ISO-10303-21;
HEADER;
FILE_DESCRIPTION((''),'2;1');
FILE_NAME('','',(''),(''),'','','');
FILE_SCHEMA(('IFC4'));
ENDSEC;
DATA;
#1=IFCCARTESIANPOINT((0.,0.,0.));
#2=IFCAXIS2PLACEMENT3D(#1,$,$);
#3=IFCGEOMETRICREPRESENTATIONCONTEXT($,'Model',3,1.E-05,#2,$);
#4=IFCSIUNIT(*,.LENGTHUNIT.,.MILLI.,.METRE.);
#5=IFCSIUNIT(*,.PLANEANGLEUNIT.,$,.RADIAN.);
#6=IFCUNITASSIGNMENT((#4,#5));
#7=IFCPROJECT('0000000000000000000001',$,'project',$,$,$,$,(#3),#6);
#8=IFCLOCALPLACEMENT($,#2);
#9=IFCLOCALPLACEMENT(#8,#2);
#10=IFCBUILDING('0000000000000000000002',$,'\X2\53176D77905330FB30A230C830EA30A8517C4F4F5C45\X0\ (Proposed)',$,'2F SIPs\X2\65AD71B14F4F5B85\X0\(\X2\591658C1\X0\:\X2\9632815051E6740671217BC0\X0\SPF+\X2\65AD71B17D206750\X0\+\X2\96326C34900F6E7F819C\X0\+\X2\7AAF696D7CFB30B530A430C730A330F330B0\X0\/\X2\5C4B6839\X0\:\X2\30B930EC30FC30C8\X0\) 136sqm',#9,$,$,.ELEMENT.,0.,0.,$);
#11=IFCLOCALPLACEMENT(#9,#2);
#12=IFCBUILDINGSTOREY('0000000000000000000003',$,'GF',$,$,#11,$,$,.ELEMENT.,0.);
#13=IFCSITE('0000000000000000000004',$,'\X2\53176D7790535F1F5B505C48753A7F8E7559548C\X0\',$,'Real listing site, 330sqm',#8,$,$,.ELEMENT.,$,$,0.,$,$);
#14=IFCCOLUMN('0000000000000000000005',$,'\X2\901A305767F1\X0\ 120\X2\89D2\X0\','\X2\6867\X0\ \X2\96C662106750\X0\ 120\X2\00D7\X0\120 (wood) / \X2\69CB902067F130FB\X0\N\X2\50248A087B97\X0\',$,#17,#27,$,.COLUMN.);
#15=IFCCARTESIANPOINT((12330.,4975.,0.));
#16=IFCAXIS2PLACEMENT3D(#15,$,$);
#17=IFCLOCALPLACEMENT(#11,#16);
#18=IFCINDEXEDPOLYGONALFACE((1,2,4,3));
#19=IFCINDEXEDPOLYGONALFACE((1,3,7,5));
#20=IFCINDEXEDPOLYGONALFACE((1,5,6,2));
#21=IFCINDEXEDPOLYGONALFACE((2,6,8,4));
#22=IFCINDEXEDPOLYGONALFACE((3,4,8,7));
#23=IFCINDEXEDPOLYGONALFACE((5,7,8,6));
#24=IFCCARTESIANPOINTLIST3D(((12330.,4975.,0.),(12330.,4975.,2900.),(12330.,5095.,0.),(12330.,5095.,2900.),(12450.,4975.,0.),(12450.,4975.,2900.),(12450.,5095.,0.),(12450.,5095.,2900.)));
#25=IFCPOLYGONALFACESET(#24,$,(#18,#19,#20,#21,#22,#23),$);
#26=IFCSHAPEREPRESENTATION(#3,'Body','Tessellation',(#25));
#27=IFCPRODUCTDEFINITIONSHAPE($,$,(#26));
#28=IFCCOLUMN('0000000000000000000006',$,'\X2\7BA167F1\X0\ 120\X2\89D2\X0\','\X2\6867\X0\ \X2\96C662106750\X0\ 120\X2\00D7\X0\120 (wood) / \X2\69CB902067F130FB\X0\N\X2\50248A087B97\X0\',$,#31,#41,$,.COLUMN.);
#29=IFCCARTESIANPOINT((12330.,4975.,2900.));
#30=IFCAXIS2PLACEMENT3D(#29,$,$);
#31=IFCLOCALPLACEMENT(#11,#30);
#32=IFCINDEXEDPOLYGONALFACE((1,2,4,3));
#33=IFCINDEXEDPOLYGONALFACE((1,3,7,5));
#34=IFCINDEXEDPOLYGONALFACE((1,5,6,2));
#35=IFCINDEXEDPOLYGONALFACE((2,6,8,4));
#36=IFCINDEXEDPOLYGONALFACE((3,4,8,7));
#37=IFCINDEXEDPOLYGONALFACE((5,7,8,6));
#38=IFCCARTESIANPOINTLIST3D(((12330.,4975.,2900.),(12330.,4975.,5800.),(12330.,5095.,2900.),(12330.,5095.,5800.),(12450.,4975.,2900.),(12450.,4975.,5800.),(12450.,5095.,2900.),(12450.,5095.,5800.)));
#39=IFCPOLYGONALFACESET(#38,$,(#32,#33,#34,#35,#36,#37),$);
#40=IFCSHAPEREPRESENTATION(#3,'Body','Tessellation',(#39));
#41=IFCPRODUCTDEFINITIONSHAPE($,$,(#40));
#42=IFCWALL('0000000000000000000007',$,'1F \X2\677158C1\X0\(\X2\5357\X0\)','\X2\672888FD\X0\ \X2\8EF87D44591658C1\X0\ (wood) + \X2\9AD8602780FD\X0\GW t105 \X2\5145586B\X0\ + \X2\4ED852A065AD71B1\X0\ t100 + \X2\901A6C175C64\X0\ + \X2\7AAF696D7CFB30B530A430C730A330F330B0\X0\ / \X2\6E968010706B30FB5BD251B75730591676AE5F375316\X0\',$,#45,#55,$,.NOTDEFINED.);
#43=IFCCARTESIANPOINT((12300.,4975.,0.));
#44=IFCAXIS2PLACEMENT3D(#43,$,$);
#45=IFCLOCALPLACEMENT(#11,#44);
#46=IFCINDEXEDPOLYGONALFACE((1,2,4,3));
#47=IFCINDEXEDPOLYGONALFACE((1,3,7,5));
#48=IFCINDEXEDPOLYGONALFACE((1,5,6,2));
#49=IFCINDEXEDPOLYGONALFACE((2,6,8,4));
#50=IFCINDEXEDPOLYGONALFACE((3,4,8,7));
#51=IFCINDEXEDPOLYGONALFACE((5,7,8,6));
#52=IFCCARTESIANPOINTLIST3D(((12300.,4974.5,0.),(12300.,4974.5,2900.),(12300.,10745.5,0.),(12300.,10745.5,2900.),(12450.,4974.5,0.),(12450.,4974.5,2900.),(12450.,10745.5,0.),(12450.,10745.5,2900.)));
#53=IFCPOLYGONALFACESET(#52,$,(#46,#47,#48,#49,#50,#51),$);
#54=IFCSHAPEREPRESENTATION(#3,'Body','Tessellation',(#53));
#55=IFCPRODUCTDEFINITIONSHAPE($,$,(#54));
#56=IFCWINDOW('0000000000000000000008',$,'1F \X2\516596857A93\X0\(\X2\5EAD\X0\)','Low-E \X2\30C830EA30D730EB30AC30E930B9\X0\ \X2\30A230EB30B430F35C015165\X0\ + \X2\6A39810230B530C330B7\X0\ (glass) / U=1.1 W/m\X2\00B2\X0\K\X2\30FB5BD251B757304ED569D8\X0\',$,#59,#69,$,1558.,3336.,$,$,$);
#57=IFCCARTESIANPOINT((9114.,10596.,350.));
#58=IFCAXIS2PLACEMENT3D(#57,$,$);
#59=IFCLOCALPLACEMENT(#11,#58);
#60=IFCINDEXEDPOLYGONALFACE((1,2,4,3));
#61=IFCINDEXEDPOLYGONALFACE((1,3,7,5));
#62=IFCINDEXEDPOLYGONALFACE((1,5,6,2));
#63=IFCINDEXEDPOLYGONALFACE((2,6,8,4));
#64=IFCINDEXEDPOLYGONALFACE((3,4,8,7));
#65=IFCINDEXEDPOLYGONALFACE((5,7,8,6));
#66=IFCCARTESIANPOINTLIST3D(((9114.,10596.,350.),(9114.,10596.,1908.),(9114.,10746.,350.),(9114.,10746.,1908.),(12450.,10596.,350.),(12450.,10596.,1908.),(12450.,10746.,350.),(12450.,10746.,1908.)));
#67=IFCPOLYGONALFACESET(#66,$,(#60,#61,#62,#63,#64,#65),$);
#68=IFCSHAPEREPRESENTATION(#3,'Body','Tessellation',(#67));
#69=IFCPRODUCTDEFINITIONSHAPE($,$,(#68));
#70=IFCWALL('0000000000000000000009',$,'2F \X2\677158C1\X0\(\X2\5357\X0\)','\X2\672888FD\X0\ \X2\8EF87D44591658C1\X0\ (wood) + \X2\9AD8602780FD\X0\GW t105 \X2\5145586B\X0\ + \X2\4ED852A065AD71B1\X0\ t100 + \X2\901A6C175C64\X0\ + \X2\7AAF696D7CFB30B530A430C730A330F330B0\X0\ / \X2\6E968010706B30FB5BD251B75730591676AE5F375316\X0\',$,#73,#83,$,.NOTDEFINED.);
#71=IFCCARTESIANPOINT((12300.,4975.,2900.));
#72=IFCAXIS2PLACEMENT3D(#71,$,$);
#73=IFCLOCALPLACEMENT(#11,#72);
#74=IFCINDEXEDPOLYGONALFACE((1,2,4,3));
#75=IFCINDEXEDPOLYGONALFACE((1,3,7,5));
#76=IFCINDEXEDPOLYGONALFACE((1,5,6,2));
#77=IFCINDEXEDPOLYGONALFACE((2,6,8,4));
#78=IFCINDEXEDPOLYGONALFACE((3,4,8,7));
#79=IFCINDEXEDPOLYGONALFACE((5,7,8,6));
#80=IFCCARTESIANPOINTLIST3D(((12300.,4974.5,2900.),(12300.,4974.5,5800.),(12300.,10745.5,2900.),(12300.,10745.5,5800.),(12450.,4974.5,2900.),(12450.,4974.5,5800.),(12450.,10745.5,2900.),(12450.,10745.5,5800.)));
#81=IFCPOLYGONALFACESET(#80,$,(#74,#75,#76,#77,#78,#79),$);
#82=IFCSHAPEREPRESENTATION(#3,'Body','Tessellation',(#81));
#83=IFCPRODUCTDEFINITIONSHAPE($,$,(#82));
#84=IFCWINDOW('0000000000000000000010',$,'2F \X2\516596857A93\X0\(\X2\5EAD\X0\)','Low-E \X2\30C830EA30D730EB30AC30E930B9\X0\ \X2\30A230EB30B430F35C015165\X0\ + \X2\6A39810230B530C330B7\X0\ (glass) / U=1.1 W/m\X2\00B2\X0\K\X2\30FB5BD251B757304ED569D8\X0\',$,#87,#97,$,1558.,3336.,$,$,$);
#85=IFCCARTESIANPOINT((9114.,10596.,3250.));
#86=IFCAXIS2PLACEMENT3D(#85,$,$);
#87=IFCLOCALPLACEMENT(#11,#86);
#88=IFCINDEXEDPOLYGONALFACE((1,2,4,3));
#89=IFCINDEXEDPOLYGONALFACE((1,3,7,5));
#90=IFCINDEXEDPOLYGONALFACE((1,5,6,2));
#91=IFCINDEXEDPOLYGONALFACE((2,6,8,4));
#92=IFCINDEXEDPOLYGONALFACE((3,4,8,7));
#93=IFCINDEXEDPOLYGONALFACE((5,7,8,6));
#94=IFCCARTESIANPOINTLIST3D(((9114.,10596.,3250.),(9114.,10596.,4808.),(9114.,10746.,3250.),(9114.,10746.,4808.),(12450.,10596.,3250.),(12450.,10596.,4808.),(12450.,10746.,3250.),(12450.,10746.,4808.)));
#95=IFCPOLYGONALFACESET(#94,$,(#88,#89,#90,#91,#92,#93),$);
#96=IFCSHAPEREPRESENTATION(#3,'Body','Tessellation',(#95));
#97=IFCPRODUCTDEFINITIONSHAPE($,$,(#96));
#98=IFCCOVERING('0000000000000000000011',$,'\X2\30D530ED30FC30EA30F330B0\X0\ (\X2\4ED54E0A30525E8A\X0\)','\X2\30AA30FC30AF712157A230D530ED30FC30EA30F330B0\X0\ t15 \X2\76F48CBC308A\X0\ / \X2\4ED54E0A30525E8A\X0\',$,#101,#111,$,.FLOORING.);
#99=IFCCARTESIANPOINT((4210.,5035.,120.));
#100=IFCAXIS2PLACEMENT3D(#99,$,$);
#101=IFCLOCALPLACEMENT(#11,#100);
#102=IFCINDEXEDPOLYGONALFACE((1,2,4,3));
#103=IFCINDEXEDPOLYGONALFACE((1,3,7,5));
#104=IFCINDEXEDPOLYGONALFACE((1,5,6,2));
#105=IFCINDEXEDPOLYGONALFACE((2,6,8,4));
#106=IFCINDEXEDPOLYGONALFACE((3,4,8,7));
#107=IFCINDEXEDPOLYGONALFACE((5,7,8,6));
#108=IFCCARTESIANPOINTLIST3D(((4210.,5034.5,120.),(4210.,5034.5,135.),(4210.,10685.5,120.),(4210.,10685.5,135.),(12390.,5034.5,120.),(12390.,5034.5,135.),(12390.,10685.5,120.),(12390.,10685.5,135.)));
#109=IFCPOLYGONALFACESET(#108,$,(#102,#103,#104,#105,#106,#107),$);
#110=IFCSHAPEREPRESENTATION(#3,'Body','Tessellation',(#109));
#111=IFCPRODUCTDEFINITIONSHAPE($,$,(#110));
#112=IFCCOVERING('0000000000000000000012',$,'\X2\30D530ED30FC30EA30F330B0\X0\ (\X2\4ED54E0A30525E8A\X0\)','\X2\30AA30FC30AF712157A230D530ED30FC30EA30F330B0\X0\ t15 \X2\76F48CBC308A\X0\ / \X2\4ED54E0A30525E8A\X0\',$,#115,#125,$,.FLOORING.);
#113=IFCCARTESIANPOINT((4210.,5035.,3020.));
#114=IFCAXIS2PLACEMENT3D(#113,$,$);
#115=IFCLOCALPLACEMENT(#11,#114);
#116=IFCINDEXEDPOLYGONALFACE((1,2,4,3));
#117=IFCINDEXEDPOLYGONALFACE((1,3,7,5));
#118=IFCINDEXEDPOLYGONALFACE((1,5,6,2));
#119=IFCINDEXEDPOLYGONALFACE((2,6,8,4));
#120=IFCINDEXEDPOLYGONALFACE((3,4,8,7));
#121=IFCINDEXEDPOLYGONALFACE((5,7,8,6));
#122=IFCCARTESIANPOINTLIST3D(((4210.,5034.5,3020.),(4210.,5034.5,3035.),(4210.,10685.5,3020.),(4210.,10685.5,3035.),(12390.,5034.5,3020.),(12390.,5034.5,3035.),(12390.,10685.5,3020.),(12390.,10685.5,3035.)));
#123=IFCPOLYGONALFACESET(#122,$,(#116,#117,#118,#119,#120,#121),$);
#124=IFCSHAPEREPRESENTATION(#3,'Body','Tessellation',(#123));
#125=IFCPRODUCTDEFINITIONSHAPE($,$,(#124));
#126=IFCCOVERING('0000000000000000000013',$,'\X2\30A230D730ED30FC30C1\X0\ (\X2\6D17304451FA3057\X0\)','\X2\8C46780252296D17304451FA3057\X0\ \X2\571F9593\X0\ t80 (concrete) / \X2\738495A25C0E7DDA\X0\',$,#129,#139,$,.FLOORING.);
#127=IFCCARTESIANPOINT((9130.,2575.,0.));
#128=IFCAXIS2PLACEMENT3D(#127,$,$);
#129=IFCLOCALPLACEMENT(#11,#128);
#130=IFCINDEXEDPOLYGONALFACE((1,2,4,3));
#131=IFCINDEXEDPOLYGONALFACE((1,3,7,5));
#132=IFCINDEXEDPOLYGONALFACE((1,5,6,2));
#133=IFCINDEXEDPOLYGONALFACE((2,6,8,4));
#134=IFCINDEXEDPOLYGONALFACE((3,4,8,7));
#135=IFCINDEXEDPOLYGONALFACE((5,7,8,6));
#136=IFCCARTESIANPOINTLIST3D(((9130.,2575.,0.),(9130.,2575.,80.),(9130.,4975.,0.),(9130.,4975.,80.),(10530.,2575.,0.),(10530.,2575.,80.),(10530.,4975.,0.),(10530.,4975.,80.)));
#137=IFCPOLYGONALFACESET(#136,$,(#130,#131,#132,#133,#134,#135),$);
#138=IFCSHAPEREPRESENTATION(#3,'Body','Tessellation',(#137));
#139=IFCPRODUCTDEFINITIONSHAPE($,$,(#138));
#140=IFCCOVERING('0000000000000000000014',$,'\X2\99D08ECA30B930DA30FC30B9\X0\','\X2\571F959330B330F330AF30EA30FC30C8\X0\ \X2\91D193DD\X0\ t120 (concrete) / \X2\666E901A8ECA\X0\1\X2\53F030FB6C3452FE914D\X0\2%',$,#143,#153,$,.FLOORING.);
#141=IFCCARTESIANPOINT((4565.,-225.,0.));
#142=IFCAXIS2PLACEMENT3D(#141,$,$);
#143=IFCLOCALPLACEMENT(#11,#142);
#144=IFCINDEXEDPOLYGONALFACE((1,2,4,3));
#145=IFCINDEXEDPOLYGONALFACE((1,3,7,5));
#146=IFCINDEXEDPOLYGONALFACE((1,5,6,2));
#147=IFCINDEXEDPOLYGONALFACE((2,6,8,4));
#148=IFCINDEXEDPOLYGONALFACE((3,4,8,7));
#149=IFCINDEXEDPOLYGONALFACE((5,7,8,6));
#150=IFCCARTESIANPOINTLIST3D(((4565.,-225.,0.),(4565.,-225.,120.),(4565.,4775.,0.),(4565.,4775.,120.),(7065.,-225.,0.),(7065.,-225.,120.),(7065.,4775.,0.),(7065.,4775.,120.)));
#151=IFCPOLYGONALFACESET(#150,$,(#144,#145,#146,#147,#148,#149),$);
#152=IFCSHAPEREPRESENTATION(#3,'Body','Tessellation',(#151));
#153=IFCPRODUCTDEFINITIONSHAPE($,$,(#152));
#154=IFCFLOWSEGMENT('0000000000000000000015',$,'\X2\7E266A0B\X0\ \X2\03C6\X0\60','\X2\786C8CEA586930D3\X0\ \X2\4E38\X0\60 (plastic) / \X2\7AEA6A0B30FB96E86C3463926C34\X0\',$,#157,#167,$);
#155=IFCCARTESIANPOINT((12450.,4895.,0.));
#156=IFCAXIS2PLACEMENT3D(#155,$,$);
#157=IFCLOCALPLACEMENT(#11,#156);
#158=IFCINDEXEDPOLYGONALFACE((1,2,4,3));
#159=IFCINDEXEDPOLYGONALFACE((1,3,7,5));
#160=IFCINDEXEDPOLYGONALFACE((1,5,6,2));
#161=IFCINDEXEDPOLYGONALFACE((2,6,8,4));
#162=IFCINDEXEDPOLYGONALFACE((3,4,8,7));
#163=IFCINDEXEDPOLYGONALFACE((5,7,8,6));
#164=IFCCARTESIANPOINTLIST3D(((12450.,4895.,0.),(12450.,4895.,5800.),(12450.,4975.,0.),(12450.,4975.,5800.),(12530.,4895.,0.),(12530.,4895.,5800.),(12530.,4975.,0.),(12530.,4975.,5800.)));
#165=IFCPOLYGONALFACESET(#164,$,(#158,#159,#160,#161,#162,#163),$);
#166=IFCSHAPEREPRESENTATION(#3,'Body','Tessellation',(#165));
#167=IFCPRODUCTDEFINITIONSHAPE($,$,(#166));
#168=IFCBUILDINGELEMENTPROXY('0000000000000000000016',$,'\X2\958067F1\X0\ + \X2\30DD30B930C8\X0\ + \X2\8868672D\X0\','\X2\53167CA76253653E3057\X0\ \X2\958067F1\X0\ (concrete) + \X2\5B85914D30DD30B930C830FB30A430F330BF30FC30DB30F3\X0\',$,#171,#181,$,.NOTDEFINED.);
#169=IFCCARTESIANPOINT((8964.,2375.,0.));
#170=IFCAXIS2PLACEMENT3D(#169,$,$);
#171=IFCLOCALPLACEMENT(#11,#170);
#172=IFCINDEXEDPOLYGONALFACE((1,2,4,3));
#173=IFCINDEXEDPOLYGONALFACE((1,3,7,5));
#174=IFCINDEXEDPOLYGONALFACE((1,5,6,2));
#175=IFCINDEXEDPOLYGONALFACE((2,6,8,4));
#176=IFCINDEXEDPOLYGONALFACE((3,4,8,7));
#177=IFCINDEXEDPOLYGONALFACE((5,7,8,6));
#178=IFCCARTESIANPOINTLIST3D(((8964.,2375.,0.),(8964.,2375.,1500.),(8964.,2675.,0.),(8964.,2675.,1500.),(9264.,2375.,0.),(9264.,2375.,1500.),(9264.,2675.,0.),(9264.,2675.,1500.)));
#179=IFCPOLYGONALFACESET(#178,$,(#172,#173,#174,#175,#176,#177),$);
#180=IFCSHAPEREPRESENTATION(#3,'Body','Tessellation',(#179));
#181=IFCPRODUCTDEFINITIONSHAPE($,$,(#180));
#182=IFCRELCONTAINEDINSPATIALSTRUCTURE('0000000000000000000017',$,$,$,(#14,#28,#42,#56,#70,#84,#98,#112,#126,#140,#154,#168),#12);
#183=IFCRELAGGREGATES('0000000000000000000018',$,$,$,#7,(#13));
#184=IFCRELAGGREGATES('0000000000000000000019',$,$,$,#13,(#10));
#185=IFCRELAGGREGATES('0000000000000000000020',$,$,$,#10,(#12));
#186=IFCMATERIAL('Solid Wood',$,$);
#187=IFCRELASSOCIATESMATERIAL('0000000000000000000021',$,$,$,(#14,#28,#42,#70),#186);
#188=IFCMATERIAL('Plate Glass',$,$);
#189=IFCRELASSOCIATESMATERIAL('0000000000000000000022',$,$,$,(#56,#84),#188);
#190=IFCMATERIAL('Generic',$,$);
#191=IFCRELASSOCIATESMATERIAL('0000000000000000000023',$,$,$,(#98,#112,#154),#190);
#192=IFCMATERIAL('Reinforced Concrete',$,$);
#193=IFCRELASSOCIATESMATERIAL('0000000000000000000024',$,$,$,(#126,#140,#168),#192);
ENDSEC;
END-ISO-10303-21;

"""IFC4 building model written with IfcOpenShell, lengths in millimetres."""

from ifc_helpers import new_model, si_unit, frame, frame_2d, origin, place, context, project, spatial, rectangle, extrude, material, element, fill, save


model = new_model("IFC4")

# Units and contexts
model_context = context("Model", 3, precision=1e-05, world=origin())
ifc_project = project(units=[si_unit("LENGTHUNIT", "METRE", prefix="MILLI"), si_unit("PLANEANGLEUNIT", "RADIAN")], contexts=[model_context])

# Site, building, storey
site_placement = place(None, origin())
site = spatial("IfcSite", under=ifc_project, at=site_placement, Name="北海道弟子屈町美留和", ObjectType="Real listing site, 330sqm", CompositionType="ELEMENT", RefElevation=0.0)
building_placement = place(site_placement, origin())
building = spatial("IfcBuilding", under=site, at=building_placement, Name="北海道・アトリエ兼住居 (Proposed)", ObjectType="2F SIPs断熱住宅(外壁:防腐処理無節SPF+断熱素材+防水透湿膜+窯業系サイディング/屋根:スレート) 136sqm", CompositionType="ELEMENT", ElevationOfRefHeight=0.0, ElevationOfTerrain=0.0)
storey_placement = place(building_placement, origin())
storey = spatial("IfcBuildingStorey", under=building, at=storey_placement, Name="GF", CompositionType="ELEMENT", Elevation=0.0)

# Columns
ifc_material_1 = material(Name="Solid Wood")
column_1_placement = place(storey_placement, frame((12330.0, 4975.0, 0.0)))
element("IfcColumn", 1, at=column_1_placement, inside=storey, material=ifc_material_1, Name="通し柱 120角", Description="桧 集成材 120×120 (wood) / 構造柱・N値計算", PredefinedType="COLUMN", context=model_context, shape_type="SweptSolid", body=[
    extrude(rectangle(XDim=120.0, YDim=120.0, at=frame_2d((60.0, 60.0))), frame((12330.0, 4975.0, 0.0)), (0.0, 0.0, 1.0), 2900.0),
])
column_2_placement = place(storey_placement, frame((12330.0, 4975.0, 2900.0)))
element("IfcColumn", 2, at=column_2_placement, inside=storey, material=ifc_material_1, Name="管柱 120角", Description="桧 集成材 120×120 (wood) / 構造柱・N値計算", PredefinedType="COLUMN", context=model_context, shape_type="SweptSolid", body=[
    extrude(rectangle(XDim=120.0, YDim=120.0, at=frame_2d((60.0, 60.0))), frame((12330.0, 4975.0, 2900.0)), (0.0, 0.0, 1.0), 2900.0),
])

# Wall, opening, window
wall_1_placement = place(storey_placement, frame((12300.0, 4975.0, 0.0)))
wall_1 = element("IfcWall", 3, at=wall_1_placement, inside=storey, material=ifc_material_1, Name="1F 東壁(南)", Description="木製 軸組外壁 (wood) + 高性能GW t105 充填 + 付加断熱 t100 + 通気層 + 窯業系サイディング / 準耐火・寒冷地外皮強化", PredefinedType="NOTDEFINED", context=model_context, shape_type="SweptSolid", body=[
    extrude(rectangle(XDim=150.0, YDim=5771.0, at=frame_2d((75.0, 2885.0))), frame((12300.0, 4975.0, 0.0)), (0.0, 0.0, 1.0), 2900.0),
])
opening_1_placement = place(storey_placement, frame((9114.0, 10596.0, 350.0)))
opening_1 = element("IfcOpeningElement", 4, at=opening_1_placement, cuts=wall_1, PredefinedType="NOTDEFINED", context=model_context, shape_type="SweptSolid", body=[
    extrude(rectangle(XDim=3336.0, YDim=150.0, at=frame_2d((1668.0, 75.0))), frame((9114.0, 10596.0, 350.0)), (0.0, 0.0, 1.0), 1558.0),
])
ifc_material_2 = material(Name="Plate Glass")
window_1_placement = place(storey_placement, frame((9114.0, 10596.0, 350.0)))
window_1 = element("IfcWindow", 5, at=window_1_placement, inside=storey, material=ifc_material_2, Name="1F 入隅窓(庭)", Description="Low-E トリプルガラス アルゴン封入 + 樹脂サッシ (glass) / U=1.1 W/m²K・寒冷地仕様", OverallHeight=1558.0, OverallWidth=3336.0, context=model_context, shape_type="SweptSolid", body=[
    extrude(rectangle(XDim=3336.0, YDim=150.0, at=frame_2d((1668.0, 75.0))), frame((9114.0, 10596.0, 350.0)), (0.0, 0.0, 1.0), 1558.0),
])
fill(opening_1, window_1)

# Wall, opening, window
wall_2_placement = place(storey_placement, frame((12300.0, 4975.0, 2900.0)))
wall_2 = element("IfcWall", 6, at=wall_2_placement, inside=storey, material=ifc_material_1, Name="2F 東壁(南)", Description="木製 軸組外壁 (wood) + 高性能GW t105 充填 + 付加断熱 t100 + 通気層 + 窯業系サイディング / 準耐火・寒冷地外皮強化", PredefinedType="NOTDEFINED", context=model_context, shape_type="SweptSolid", body=[
    extrude(rectangle(XDim=150.0, YDim=5771.0, at=frame_2d((75.0, 2885.0))), frame((12300.0, 4975.0, 2900.0)), (0.0, 0.0, 1.0), 2900.0),
])
opening_2_placement = place(storey_placement, frame((9114.0, 10596.0, 3250.0)))
opening_2 = element("IfcOpeningElement", 7, at=opening_2_placement, cuts=wall_2, PredefinedType="NOTDEFINED", context=model_context, shape_type="SweptSolid", body=[
    extrude(rectangle(XDim=3336.0, YDim=150.0, at=frame_2d((1668.0, 75.0))), frame((9114.0, 10596.0, 3250.0)), (0.0, 0.0, 1.0), 1558.0),
])
window_2_placement = place(storey_placement, frame((9114.0, 10596.0, 3250.0)))
window_2 = element("IfcWindow", 8, at=window_2_placement, inside=storey, material=ifc_material_2, Name="2F 入隅窓(庭)", Description="Low-E トリプルガラス アルゴン封入 + 樹脂サッシ (glass) / U=1.1 W/m²K・寒冷地仕様", OverallHeight=1558.0, OverallWidth=3336.0, context=model_context, shape_type="SweptSolid", body=[
    extrude(rectangle(XDim=3336.0, YDim=150.0, at=frame_2d((1668.0, 75.0))), frame((9114.0, 10596.0, 3250.0)), (0.0, 0.0, 1.0), 1558.0),
])
fill(opening_2, window_2)

# Coverings
ifc_material_3 = material(Name="Generic")
covering_1_placement = place(storey_placement, frame((4210.0, 5035.0, 120.0)))
element("IfcCovering", 9, at=covering_1_placement, inside=storey, material=ifc_material_3, Name="フローリング (仕上げ床)", Description="オーク無垢フローリング t15 直貼り / 仕上げ床", PredefinedType="FLOORING", context=model_context, shape_type="SweptSolid", body=[
    extrude(rectangle(XDim=8180.0, YDim=5651.0, at=frame_2d((4090.0, 2825.0))), frame((4210.0, 5035.0, 120.0)), (0.0, 0.0, 1.0), 15.0),
])
covering_2_placement = place(storey_placement, frame((4210.0, 5035.0, 3020.0)))
element("IfcCovering", 10, at=covering_2_placement, inside=storey, material=ifc_material_3, Name="フローリング (仕上げ床)", Description="オーク無垢フローリング t15 直貼り / 仕上げ床", PredefinedType="FLOORING", context=model_context, shape_type="SweptSolid", body=[
    extrude(rectangle(XDim=8180.0, YDim=5651.0, at=frame_2d((4090.0, 2825.0))), frame((4210.0, 5035.0, 3020.0)), (0.0, 0.0, 1.0), 15.0),
])
ifc_material_4 = material(Name="Reinforced Concrete")
covering_3_placement = place(storey_placement, frame((9130.0, 2575.0, 0.0)))
element("IfcCovering", 11, at=covering_3_placement, inside=storey, material=ifc_material_4, Name="アプローチ (洗い出し)", Description="豆砂利洗い出し 土間 t80 (concrete) / 玄関導線", PredefinedType="FLOORING", context=model_context, shape_type="SweptSolid", body=[
    extrude(rectangle(XDim=1400.0, YDim=2400.0, at=frame_2d((700.0, 1200.0))), frame((9130.0, 2575.0, 0.0)), (0.0, 0.0, 1.0), 80.0),
])
covering_4_placement = place(storey_placement, frame((4565.0, -225.0, 0.0)))
element("IfcCovering", 12, at=covering_4_placement, inside=storey, material=ifc_material_4, Name="駐車スペース", Description="土間コンクリート 金鏝 t120 (concrete) / 普通車1台・水勾配2%", PredefinedType="FLOORING", context=model_context, shape_type="SweptSolid", body=[
    extrude(rectangle(XDim=2500.0, YDim=5000.0, at=frame_2d((1250.0, 2500.0))), frame((4565.0, -225.0, 0.0)), (0.0, 0.0, 1.0), 120.0),
])

# Flow segment
flow_segment_placement = place(storey_placement, frame((12450.0, 4895.0, 0.0)))
element("IfcFlowSegment", 13, at=flow_segment_placement, inside=storey, material=ifc_material_3, Name="縦樋 φ60", Description="硬質塩ビ 丸60 (plastic) / 竪樋・雨水排水", context=model_context, shape_type="SweptSolid", body=[
    extrude(rectangle(XDim=80.0, YDim=80.0, at=frame_2d((40.0, 40.0))), frame((12450.0, 4895.0, 0.0)), (0.0, 0.0, 1.0), 5800.0),
])

# Building element proxy
proxy_placement = place(storey_placement, frame((8964.0, 2375.0, 0.0)))
element("IfcBuildingElementProxy", 14, at=proxy_placement, inside=storey, material=ifc_material_4, Name="門柱 + ポスト + 表札", Description="化粧打放し 門柱 (concrete) + 宅配ポスト・インターホン", PredefinedType="NOTDEFINED", context=model_context, shape_type="SweptSolid", body=[
    extrude(rectangle(XDim=300.0, YDim=300.0, at=frame_2d((150.0, 150.0))), frame((8964.0, 2375.0, 0.0)), (0.0, 0.0, 1.0), 1500.0),
])

save(model, "model.ifc")
